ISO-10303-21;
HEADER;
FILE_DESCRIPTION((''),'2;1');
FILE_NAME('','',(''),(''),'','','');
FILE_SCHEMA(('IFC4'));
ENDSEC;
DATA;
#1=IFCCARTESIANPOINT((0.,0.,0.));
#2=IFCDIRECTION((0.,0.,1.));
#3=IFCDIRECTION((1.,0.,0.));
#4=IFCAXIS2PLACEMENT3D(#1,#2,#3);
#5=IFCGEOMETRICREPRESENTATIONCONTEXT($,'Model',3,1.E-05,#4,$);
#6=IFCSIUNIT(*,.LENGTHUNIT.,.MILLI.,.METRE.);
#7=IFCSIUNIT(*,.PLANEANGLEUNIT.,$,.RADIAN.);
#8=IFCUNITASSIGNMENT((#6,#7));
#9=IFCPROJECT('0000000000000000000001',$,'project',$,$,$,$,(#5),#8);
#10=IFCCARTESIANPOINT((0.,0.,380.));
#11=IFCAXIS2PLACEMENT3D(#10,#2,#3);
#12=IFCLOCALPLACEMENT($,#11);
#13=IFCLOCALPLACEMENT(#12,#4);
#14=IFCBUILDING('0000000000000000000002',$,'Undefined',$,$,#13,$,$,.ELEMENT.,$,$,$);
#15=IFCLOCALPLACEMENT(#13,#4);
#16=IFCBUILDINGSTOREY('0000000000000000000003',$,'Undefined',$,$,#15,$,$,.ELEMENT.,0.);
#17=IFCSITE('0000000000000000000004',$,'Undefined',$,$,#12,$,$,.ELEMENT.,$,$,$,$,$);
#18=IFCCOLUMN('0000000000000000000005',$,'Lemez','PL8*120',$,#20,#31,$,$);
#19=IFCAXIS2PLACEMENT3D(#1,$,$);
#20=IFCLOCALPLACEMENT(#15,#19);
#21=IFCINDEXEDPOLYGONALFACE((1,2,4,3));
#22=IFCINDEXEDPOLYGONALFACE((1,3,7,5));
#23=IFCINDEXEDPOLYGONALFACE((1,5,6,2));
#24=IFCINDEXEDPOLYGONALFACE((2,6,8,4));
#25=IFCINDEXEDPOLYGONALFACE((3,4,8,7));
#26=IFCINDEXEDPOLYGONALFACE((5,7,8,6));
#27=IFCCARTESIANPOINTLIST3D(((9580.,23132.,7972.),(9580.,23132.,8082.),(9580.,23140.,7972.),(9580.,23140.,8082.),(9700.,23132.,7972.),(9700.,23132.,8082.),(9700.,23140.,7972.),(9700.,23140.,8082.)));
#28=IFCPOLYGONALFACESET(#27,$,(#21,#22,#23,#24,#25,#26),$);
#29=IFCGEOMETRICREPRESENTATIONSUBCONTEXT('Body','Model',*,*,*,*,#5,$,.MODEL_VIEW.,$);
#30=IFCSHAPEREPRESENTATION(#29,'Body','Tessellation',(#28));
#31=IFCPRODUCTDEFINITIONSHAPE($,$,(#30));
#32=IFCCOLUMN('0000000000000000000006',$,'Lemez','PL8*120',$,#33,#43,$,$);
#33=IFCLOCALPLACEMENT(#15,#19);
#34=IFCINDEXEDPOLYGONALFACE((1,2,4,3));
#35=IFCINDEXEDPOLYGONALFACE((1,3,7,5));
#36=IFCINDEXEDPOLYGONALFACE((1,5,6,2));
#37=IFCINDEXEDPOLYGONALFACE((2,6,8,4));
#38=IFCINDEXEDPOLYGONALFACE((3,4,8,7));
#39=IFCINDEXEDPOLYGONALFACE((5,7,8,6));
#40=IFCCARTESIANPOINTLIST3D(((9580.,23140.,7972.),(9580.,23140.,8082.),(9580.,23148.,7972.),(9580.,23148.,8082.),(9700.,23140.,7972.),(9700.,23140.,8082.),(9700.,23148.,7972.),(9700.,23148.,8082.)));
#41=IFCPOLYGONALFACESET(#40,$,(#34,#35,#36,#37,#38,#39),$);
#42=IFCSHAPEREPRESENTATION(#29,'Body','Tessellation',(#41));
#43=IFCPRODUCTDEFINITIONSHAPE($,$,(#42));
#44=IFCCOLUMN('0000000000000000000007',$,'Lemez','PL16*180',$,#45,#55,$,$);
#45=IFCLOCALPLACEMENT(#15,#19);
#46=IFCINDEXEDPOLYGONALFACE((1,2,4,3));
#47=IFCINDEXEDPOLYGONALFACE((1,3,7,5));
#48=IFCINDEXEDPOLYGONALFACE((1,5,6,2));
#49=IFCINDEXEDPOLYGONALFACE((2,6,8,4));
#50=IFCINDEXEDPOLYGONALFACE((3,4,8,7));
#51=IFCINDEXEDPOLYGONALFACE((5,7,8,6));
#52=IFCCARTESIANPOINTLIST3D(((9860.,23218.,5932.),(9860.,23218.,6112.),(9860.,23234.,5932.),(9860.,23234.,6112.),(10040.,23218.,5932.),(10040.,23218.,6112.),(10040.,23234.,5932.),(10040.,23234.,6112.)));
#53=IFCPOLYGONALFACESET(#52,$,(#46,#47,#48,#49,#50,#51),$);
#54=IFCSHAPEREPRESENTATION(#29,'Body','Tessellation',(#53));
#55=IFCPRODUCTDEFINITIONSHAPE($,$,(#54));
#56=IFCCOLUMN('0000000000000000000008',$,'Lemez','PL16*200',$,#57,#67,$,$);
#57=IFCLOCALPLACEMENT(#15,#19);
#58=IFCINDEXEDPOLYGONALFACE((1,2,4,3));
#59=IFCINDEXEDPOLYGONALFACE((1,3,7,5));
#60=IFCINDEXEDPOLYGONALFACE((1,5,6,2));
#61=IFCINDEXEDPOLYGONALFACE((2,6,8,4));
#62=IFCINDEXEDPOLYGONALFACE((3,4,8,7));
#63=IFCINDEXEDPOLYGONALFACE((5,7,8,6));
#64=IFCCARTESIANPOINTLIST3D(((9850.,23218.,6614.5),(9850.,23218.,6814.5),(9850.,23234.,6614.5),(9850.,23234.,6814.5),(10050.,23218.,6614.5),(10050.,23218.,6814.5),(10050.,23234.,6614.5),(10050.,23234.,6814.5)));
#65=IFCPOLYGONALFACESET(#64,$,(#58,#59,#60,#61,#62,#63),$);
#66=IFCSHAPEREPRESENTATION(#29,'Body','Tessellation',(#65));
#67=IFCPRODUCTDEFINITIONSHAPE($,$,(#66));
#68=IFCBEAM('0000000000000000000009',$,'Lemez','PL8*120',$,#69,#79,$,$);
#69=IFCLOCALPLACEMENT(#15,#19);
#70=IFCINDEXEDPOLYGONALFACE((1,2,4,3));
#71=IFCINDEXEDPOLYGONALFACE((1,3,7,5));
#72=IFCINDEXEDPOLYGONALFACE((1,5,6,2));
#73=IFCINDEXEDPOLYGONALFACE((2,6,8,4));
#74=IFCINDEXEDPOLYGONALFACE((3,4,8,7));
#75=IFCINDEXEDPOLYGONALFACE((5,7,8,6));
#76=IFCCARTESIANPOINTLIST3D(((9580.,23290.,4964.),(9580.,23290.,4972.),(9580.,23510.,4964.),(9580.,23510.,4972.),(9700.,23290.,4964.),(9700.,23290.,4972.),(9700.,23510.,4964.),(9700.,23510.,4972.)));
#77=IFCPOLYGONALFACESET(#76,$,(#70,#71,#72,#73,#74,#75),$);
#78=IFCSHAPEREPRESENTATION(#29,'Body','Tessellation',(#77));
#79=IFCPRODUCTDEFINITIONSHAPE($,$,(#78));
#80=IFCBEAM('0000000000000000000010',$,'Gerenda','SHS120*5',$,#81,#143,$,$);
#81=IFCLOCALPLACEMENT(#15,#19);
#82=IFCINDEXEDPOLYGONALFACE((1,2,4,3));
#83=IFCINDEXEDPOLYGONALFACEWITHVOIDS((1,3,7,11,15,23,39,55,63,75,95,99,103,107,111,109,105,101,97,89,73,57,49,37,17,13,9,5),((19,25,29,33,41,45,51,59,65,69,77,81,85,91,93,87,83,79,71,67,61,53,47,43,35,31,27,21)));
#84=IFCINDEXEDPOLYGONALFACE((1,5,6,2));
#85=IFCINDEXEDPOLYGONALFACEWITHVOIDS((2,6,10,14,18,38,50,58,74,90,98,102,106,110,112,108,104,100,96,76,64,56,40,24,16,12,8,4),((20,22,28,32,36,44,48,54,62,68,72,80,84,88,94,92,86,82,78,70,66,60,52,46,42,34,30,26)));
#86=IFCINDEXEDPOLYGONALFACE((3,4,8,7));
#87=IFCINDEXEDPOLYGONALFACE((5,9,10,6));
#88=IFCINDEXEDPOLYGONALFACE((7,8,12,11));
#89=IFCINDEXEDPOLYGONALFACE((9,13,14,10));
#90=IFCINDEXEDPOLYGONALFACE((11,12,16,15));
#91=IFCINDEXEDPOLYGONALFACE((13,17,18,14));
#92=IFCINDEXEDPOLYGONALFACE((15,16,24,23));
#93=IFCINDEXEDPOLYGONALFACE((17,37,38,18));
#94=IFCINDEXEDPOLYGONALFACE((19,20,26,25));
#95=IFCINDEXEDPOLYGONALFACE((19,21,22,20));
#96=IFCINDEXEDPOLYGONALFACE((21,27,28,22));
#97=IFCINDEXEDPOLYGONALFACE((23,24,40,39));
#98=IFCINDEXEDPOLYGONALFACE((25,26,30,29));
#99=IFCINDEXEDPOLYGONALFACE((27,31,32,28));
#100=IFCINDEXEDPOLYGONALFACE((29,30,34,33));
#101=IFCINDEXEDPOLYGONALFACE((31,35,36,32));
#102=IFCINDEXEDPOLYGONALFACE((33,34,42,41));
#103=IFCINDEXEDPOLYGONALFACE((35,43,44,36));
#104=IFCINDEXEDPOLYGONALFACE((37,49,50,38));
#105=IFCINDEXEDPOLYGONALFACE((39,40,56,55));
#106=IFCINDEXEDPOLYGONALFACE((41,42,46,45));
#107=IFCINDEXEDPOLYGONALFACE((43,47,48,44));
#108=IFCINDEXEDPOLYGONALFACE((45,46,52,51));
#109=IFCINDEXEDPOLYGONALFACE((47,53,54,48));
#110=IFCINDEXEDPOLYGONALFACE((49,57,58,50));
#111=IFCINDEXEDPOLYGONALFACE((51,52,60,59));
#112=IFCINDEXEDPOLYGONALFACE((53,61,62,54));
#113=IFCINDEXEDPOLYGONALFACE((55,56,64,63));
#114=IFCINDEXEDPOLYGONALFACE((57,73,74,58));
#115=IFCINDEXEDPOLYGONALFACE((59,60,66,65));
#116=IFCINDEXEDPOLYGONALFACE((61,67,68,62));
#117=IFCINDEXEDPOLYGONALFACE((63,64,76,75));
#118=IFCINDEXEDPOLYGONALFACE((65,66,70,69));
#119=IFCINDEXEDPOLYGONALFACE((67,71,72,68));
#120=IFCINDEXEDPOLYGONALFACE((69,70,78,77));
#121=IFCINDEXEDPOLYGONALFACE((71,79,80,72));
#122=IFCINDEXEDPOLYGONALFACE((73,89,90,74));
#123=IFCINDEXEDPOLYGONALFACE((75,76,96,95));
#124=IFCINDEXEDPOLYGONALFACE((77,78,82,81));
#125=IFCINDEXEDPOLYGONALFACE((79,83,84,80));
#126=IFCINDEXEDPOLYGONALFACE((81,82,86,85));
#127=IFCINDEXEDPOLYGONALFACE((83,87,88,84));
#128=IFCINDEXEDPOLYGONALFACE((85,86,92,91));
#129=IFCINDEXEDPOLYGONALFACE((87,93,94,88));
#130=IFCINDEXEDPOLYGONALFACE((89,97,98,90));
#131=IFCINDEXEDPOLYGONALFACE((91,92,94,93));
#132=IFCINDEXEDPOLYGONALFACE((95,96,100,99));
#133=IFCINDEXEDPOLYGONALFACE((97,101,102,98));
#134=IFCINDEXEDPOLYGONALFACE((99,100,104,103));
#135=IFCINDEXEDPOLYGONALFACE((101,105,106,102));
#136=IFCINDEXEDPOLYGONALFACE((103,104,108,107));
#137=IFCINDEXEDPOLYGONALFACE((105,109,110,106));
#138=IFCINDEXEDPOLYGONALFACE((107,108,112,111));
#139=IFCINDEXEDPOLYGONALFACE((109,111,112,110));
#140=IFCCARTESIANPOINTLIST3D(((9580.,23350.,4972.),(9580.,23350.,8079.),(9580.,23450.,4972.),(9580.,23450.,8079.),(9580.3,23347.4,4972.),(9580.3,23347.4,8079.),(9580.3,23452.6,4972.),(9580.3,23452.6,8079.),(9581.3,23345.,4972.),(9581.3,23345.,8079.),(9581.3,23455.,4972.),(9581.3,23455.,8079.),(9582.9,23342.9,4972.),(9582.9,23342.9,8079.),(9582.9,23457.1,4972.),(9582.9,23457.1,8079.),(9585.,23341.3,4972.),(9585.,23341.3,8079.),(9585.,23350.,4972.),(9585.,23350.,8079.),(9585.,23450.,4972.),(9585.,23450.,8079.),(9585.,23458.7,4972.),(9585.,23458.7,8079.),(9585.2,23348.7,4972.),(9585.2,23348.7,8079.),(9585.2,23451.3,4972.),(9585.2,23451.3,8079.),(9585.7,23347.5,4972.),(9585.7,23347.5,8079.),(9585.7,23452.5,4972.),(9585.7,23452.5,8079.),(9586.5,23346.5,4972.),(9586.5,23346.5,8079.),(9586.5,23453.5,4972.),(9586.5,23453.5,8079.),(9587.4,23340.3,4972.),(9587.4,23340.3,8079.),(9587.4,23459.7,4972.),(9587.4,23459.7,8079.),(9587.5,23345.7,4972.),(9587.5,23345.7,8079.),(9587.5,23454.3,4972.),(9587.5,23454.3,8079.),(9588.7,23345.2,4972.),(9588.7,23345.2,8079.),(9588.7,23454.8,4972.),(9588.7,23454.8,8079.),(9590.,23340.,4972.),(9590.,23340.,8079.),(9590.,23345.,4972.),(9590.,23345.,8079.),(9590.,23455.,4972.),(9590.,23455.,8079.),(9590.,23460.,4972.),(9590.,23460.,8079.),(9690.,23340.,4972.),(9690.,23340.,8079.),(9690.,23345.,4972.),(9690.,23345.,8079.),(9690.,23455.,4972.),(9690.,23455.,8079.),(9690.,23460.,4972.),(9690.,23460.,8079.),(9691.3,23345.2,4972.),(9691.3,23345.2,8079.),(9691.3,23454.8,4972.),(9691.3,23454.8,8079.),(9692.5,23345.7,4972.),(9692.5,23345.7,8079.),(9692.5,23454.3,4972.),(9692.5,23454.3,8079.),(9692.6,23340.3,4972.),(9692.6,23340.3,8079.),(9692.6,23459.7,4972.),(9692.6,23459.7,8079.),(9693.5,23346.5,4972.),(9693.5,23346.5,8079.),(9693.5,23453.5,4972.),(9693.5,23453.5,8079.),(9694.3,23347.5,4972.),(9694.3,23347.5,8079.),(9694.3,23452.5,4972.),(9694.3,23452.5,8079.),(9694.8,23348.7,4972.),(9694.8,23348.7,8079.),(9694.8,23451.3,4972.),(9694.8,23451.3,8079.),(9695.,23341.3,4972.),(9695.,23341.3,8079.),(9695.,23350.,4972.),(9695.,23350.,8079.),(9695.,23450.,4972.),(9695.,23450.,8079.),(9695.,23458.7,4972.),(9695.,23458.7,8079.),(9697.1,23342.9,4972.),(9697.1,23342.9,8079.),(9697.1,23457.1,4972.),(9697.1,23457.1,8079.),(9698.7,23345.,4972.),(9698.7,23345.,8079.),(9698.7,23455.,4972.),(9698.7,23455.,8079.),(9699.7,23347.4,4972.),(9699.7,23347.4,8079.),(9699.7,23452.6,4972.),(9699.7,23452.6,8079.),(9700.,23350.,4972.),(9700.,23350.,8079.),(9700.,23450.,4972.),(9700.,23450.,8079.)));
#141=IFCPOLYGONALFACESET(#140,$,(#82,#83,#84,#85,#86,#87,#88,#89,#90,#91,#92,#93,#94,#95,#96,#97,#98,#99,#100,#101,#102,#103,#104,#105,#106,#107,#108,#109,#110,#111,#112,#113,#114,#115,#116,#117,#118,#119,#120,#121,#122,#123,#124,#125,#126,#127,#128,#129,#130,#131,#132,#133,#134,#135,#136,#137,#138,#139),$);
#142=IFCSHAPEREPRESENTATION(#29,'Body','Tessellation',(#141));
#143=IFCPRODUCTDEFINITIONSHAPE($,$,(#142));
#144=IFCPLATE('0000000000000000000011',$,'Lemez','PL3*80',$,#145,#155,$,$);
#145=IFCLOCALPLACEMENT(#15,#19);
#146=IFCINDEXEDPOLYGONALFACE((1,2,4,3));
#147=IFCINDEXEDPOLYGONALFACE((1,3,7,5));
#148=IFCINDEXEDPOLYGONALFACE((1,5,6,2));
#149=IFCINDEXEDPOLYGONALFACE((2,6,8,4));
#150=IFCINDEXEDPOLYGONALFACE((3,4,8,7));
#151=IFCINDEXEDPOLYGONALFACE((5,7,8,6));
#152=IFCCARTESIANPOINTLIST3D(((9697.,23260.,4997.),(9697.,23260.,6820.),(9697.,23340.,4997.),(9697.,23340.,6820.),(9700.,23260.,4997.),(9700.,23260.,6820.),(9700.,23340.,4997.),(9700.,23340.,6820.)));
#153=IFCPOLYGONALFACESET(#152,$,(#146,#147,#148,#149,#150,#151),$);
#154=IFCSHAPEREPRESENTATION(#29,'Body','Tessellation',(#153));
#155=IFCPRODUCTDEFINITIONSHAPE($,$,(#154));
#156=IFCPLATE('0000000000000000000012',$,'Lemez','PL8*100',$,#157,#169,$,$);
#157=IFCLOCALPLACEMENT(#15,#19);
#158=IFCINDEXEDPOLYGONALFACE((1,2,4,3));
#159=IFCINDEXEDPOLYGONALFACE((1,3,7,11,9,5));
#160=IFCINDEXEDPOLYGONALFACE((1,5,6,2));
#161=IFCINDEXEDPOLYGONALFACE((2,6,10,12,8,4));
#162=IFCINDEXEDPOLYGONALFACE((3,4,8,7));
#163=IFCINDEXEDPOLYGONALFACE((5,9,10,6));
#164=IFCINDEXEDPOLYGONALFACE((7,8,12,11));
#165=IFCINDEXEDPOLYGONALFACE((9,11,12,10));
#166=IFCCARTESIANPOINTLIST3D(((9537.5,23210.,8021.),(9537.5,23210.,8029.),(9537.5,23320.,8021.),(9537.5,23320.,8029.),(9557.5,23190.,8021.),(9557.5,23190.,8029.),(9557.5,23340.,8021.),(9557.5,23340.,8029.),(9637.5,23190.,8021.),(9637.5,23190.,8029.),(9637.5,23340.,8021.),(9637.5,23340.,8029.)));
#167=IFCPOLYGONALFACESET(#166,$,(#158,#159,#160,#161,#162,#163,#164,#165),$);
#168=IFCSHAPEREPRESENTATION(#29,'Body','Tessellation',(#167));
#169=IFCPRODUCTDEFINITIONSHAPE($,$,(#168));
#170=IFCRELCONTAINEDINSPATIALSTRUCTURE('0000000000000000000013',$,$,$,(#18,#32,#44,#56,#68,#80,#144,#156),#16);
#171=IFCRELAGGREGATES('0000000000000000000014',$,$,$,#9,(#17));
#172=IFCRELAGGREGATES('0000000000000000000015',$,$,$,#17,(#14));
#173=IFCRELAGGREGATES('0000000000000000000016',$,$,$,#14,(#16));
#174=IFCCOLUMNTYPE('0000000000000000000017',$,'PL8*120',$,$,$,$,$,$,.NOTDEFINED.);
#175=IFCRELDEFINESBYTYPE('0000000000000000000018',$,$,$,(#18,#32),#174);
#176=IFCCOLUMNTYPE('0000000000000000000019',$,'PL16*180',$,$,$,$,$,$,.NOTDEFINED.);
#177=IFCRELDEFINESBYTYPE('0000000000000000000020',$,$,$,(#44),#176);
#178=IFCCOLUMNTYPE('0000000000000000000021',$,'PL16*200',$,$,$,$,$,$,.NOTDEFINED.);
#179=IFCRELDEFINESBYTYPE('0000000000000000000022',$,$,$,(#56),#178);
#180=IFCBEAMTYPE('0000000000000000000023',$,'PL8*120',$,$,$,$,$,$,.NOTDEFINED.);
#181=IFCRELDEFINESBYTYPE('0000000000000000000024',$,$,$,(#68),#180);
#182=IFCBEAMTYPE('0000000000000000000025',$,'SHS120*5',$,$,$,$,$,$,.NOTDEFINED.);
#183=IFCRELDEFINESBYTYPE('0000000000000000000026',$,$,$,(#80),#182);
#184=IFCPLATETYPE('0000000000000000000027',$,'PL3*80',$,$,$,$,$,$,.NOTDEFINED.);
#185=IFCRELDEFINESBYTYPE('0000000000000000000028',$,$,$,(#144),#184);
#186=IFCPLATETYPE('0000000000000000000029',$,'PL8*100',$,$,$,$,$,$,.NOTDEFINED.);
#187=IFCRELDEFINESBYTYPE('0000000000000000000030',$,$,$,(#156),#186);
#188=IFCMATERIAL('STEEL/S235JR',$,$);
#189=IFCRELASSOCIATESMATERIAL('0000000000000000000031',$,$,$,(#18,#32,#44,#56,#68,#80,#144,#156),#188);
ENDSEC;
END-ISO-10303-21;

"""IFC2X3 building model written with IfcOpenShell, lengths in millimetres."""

from ifc_helpers import new_model, si_unit, frame, origin_with_axes, origin_2d_with_axis, place, context, subcontext, project, spatial, polyline, rectangle, hollow_rectangle, outline, extrude, clip, halfspace, material, type_object, element, save


model = new_model("IFC2X3")

# Units and contexts
model_context = context("Model", 3, precision=1e-05, world=origin_with_axes())
body_context = subcontext(model_context, "Body", "Model", "MODEL_VIEW")
ifc_project = project(units=[si_unit("LENGTHUNIT", "METRE", prefix="MILLI"), si_unit("PLANEANGLEUNIT", "RADIAN")], contexts=[model_context])

# Site, building, storey
site_placement = place(None, frame((0.0, 0.0, 380.0), z_axis=(0.0, 0.0, 1.0), x_axis=(1.0, 0.0, 0.0)))
site = spatial("IfcSite", under=ifc_project, at=site_placement, Name="Undefined", CompositionType="ELEMENT")
building_placement = place(site_placement, origin_with_axes())
building = spatial("IfcBuilding", under=site, at=building_placement, Name="Undefined", CompositionType="ELEMENT")
storey_placement = place(building_placement, origin_with_axes())
storey = spatial("IfcBuildingStorey", under=building, at=storey_placement, Name="Undefined", CompositionType="ELEMENT", Elevation=0.0)

# Columns
ifc_material_1 = material(Name="STEEL/S235JR")
column_type_1 = type_object("IfcColumnType", Name="PL8*120", PredefinedType="NOTDEFINED")
for number, where, z_axis, x_axis, name in (
    (1, (9640.0, 23136.0, 7972.0), (0.0, 0.0, 1.0), (-1.0, 0.0, 0.0), "Lemez"),
    (2, (9640.0, 23144.0, 7972.0), (0.0, 0.0, 1.0), (-1.0, 0.0, 0.0), "Lemez"),
):
    element("IfcColumn", number, at=place(storey_placement, frame(where, z_axis=z_axis, x_axis=x_axis)), inside=storey, type_object=column_type_1, material=ifc_material_1, Name=name, Description="PL8*120", context=body_context, shape_type="SweptSolid", body=[
        extrude(rectangle(XDim=8.0, YDim=120.0, at=origin_2d_with_axis()), frame((0.0, 0.0, 110.0), z_axis=(0.0, 0.0, -1.0), x_axis=(0.0, 1.0, 0.0)), (0.0, 0.0, 1.0), 110.0),
    ])
column_type_2 = type_object("IfcColumnType", Name="PL16*180", PredefinedType="NOTDEFINED")
column_1_placement = place(storey_placement, frame((9950.0, 23226.0, 5932.0), z_axis=(0.0, 0.0, 1.0), x_axis=(-1.0, 0.0, 0.0)))
element("IfcColumn", 3, at=column_1_placement, inside=storey, type_object=column_type_2, material=ifc_material_1, Name="Lemez", Description="PL16*180", context=body_context, shape_type="SweptSolid", body=[
    extrude(rectangle(XDim=16.0, YDim=180.0, at=origin_2d_with_axis()), frame((0.0, 0.0, 180.0), z_axis=(0.0, 0.0, -1.0), x_axis=(0.0, 1.0, 0.0)), (0.0, 0.0, 1.0), 180.0),
])
column_type_3 = type_object("IfcColumnType", Name="PL16*200", PredefinedType="NOTDEFINED")
column_2_placement = place(storey_placement, frame((9950.0, 23226.0, 6614.5), z_axis=(0.0, 0.0, 1.0), x_axis=(-1.0, 0.0, 0.0)))
element("IfcColumn", 4, at=column_2_placement, inside=storey, type_object=column_type_3, material=ifc_material_1, Name="Lemez", Description="PL16*200", context=body_context, shape_type="SweptSolid", body=[
    extrude(rectangle(XDim=16.0, YDim=200.0, at=origin_2d_with_axis()), frame((0.0, 0.0, 200.0), z_axis=(0.0, 0.0, -1.0), x_axis=(0.0, 1.0, 0.0)), (0.0, 0.0, 1.0), 200.0),
])

# Beams
beam_type_1 = type_object("IfcBeamType", Name="PL8*120", PredefinedType="NOTDEFINED")
beam_1_placement = place(storey_placement, frame((9640.0, 23290.0, 4968.0), z_axis=(-1.0, 0.0, 0.0), x_axis=(0.0, 1.0, 0.0)))
element("IfcBeam", 5, at=beam_1_placement, inside=storey, type_object=beam_type_1, material=ifc_material_1, Name="Lemez", Description="PL8*120", context=body_context, shape_type="SweptSolid", body=[
    extrude(rectangle(XDim=8.0, YDim=120.0, at=origin_2d_with_axis()), frame((220.0, 0.0, 0.0), z_axis=(-1.0, 0.0, 0.0), x_axis=(0.0, -1.0, 0.0)), (0.0, 0.0, 1.0), 220.0),
])
beam_type_2 = type_object("IfcBeamType", Name="SHS120*5", PredefinedType="NOTDEFINED")
beam_2_placement = place(storey_placement, frame((9640.0, 23400.0, 8079.0), z_axis=(0.0, 1.0, 0.0), x_axis=(0.0, 0.0, -1.0)))
element("IfcBeam", 6, at=beam_2_placement, inside=storey, type_object=beam_type_2, material=ifc_material_1, Name="Gerenda", Description="SHS120*5", context=body_context, shape_type="Clipping", body=[
    clip(clip(clip(extrude(hollow_rectangle(XDim=120.0, YDim=120.0, WallThickness=5.0, InnerFilletRadius=5.0, OuterFilletRadius=10.0, at=origin_2d_with_axis()), frame((3115.0, 0.0, 0.0), z_axis=(-1.0, 0.0, 0.0), x_axis=(0.0, -1.0, 0.0)), (0.0, 0.0, 1.0), 3115.0), halfspace(frame((3107.0, -60.0, -60.0), z_axis=(1.0, 0.0, 0.0), x_axis=(0.0, 0.0, 1.0)), False)), halfspace(frame((3107.0, 0.0, -60.0), z_axis=(-1.0, 0.0, 0.0), x_axis=(0.0, 1.0, 0.0)), True)), halfspace(frame((0.0, 0.0, -60.0), z_axis=(1.0, 0.0, 0.0), x_axis=(0.0, -1.0, 0.0)), True)),
])

# Plates
plate_type_1 = type_object("IfcPlateType", Name="PL3*80", PredefinedType="NOTDEFINED")
plate_1_placement = place(storey_placement, frame((9698.5, 23260.0, 4997.0), z_axis=(1.0, 0.0, 0.0), x_axis=(0.0, 1.0, 0.0)))
element("IfcPlate", 7, at=plate_1_placement, inside=storey, type_object=plate_type_1, material=ifc_material_1, Name="Lemez", Description="PL3*80", context=body_context, shape_type="SweptSolid", body=[
    extrude(outline(polyline([(0.0, 0.0), (80.0, 0.0), (80.0, 1823.0), (0.0, 1823.0), (0.0, 0.0)])), frame((0.0, 0.0, -1.5), z_axis=(0.0, 0.0, 1.0), x_axis=(1.0, 0.0, 0.0)), (0.0, 0.0, 1.0), 3.0),
])
plate_type_2 = type_object("IfcPlateType", Name="PL8*100", PredefinedType="NOTDEFINED")
plate_2_placement = place(storey_placement, frame((9557.5, 23190.0, 8025.0), z_axis=(0.0, 0.0, 1.0), x_axis=(1.0, 0.0, 0.0)))
element("IfcPlate", 8, at=plate_2_placement, inside=storey, type_object=plate_type_2, material=ifc_material_1, Name="Lemez", Description="PL8*100", context=body_context, shape_type="SweptSolid", body=[
    extrude(outline(polyline([(0.0, 0.0), (80.0, 0.0), (80.0, 150.0), (0.0, 150.0), (-20.0, 130.0), (-20.0, 20.0), (0.0, 0.0)])), frame((0.0, 0.0, -4.0), z_axis=(0.0, 0.0, 1.0), x_axis=(1.0, 0.0, 0.0)), (0.0, 0.0, 1.0), 8.0),
])

save(model, "model.ifc")
